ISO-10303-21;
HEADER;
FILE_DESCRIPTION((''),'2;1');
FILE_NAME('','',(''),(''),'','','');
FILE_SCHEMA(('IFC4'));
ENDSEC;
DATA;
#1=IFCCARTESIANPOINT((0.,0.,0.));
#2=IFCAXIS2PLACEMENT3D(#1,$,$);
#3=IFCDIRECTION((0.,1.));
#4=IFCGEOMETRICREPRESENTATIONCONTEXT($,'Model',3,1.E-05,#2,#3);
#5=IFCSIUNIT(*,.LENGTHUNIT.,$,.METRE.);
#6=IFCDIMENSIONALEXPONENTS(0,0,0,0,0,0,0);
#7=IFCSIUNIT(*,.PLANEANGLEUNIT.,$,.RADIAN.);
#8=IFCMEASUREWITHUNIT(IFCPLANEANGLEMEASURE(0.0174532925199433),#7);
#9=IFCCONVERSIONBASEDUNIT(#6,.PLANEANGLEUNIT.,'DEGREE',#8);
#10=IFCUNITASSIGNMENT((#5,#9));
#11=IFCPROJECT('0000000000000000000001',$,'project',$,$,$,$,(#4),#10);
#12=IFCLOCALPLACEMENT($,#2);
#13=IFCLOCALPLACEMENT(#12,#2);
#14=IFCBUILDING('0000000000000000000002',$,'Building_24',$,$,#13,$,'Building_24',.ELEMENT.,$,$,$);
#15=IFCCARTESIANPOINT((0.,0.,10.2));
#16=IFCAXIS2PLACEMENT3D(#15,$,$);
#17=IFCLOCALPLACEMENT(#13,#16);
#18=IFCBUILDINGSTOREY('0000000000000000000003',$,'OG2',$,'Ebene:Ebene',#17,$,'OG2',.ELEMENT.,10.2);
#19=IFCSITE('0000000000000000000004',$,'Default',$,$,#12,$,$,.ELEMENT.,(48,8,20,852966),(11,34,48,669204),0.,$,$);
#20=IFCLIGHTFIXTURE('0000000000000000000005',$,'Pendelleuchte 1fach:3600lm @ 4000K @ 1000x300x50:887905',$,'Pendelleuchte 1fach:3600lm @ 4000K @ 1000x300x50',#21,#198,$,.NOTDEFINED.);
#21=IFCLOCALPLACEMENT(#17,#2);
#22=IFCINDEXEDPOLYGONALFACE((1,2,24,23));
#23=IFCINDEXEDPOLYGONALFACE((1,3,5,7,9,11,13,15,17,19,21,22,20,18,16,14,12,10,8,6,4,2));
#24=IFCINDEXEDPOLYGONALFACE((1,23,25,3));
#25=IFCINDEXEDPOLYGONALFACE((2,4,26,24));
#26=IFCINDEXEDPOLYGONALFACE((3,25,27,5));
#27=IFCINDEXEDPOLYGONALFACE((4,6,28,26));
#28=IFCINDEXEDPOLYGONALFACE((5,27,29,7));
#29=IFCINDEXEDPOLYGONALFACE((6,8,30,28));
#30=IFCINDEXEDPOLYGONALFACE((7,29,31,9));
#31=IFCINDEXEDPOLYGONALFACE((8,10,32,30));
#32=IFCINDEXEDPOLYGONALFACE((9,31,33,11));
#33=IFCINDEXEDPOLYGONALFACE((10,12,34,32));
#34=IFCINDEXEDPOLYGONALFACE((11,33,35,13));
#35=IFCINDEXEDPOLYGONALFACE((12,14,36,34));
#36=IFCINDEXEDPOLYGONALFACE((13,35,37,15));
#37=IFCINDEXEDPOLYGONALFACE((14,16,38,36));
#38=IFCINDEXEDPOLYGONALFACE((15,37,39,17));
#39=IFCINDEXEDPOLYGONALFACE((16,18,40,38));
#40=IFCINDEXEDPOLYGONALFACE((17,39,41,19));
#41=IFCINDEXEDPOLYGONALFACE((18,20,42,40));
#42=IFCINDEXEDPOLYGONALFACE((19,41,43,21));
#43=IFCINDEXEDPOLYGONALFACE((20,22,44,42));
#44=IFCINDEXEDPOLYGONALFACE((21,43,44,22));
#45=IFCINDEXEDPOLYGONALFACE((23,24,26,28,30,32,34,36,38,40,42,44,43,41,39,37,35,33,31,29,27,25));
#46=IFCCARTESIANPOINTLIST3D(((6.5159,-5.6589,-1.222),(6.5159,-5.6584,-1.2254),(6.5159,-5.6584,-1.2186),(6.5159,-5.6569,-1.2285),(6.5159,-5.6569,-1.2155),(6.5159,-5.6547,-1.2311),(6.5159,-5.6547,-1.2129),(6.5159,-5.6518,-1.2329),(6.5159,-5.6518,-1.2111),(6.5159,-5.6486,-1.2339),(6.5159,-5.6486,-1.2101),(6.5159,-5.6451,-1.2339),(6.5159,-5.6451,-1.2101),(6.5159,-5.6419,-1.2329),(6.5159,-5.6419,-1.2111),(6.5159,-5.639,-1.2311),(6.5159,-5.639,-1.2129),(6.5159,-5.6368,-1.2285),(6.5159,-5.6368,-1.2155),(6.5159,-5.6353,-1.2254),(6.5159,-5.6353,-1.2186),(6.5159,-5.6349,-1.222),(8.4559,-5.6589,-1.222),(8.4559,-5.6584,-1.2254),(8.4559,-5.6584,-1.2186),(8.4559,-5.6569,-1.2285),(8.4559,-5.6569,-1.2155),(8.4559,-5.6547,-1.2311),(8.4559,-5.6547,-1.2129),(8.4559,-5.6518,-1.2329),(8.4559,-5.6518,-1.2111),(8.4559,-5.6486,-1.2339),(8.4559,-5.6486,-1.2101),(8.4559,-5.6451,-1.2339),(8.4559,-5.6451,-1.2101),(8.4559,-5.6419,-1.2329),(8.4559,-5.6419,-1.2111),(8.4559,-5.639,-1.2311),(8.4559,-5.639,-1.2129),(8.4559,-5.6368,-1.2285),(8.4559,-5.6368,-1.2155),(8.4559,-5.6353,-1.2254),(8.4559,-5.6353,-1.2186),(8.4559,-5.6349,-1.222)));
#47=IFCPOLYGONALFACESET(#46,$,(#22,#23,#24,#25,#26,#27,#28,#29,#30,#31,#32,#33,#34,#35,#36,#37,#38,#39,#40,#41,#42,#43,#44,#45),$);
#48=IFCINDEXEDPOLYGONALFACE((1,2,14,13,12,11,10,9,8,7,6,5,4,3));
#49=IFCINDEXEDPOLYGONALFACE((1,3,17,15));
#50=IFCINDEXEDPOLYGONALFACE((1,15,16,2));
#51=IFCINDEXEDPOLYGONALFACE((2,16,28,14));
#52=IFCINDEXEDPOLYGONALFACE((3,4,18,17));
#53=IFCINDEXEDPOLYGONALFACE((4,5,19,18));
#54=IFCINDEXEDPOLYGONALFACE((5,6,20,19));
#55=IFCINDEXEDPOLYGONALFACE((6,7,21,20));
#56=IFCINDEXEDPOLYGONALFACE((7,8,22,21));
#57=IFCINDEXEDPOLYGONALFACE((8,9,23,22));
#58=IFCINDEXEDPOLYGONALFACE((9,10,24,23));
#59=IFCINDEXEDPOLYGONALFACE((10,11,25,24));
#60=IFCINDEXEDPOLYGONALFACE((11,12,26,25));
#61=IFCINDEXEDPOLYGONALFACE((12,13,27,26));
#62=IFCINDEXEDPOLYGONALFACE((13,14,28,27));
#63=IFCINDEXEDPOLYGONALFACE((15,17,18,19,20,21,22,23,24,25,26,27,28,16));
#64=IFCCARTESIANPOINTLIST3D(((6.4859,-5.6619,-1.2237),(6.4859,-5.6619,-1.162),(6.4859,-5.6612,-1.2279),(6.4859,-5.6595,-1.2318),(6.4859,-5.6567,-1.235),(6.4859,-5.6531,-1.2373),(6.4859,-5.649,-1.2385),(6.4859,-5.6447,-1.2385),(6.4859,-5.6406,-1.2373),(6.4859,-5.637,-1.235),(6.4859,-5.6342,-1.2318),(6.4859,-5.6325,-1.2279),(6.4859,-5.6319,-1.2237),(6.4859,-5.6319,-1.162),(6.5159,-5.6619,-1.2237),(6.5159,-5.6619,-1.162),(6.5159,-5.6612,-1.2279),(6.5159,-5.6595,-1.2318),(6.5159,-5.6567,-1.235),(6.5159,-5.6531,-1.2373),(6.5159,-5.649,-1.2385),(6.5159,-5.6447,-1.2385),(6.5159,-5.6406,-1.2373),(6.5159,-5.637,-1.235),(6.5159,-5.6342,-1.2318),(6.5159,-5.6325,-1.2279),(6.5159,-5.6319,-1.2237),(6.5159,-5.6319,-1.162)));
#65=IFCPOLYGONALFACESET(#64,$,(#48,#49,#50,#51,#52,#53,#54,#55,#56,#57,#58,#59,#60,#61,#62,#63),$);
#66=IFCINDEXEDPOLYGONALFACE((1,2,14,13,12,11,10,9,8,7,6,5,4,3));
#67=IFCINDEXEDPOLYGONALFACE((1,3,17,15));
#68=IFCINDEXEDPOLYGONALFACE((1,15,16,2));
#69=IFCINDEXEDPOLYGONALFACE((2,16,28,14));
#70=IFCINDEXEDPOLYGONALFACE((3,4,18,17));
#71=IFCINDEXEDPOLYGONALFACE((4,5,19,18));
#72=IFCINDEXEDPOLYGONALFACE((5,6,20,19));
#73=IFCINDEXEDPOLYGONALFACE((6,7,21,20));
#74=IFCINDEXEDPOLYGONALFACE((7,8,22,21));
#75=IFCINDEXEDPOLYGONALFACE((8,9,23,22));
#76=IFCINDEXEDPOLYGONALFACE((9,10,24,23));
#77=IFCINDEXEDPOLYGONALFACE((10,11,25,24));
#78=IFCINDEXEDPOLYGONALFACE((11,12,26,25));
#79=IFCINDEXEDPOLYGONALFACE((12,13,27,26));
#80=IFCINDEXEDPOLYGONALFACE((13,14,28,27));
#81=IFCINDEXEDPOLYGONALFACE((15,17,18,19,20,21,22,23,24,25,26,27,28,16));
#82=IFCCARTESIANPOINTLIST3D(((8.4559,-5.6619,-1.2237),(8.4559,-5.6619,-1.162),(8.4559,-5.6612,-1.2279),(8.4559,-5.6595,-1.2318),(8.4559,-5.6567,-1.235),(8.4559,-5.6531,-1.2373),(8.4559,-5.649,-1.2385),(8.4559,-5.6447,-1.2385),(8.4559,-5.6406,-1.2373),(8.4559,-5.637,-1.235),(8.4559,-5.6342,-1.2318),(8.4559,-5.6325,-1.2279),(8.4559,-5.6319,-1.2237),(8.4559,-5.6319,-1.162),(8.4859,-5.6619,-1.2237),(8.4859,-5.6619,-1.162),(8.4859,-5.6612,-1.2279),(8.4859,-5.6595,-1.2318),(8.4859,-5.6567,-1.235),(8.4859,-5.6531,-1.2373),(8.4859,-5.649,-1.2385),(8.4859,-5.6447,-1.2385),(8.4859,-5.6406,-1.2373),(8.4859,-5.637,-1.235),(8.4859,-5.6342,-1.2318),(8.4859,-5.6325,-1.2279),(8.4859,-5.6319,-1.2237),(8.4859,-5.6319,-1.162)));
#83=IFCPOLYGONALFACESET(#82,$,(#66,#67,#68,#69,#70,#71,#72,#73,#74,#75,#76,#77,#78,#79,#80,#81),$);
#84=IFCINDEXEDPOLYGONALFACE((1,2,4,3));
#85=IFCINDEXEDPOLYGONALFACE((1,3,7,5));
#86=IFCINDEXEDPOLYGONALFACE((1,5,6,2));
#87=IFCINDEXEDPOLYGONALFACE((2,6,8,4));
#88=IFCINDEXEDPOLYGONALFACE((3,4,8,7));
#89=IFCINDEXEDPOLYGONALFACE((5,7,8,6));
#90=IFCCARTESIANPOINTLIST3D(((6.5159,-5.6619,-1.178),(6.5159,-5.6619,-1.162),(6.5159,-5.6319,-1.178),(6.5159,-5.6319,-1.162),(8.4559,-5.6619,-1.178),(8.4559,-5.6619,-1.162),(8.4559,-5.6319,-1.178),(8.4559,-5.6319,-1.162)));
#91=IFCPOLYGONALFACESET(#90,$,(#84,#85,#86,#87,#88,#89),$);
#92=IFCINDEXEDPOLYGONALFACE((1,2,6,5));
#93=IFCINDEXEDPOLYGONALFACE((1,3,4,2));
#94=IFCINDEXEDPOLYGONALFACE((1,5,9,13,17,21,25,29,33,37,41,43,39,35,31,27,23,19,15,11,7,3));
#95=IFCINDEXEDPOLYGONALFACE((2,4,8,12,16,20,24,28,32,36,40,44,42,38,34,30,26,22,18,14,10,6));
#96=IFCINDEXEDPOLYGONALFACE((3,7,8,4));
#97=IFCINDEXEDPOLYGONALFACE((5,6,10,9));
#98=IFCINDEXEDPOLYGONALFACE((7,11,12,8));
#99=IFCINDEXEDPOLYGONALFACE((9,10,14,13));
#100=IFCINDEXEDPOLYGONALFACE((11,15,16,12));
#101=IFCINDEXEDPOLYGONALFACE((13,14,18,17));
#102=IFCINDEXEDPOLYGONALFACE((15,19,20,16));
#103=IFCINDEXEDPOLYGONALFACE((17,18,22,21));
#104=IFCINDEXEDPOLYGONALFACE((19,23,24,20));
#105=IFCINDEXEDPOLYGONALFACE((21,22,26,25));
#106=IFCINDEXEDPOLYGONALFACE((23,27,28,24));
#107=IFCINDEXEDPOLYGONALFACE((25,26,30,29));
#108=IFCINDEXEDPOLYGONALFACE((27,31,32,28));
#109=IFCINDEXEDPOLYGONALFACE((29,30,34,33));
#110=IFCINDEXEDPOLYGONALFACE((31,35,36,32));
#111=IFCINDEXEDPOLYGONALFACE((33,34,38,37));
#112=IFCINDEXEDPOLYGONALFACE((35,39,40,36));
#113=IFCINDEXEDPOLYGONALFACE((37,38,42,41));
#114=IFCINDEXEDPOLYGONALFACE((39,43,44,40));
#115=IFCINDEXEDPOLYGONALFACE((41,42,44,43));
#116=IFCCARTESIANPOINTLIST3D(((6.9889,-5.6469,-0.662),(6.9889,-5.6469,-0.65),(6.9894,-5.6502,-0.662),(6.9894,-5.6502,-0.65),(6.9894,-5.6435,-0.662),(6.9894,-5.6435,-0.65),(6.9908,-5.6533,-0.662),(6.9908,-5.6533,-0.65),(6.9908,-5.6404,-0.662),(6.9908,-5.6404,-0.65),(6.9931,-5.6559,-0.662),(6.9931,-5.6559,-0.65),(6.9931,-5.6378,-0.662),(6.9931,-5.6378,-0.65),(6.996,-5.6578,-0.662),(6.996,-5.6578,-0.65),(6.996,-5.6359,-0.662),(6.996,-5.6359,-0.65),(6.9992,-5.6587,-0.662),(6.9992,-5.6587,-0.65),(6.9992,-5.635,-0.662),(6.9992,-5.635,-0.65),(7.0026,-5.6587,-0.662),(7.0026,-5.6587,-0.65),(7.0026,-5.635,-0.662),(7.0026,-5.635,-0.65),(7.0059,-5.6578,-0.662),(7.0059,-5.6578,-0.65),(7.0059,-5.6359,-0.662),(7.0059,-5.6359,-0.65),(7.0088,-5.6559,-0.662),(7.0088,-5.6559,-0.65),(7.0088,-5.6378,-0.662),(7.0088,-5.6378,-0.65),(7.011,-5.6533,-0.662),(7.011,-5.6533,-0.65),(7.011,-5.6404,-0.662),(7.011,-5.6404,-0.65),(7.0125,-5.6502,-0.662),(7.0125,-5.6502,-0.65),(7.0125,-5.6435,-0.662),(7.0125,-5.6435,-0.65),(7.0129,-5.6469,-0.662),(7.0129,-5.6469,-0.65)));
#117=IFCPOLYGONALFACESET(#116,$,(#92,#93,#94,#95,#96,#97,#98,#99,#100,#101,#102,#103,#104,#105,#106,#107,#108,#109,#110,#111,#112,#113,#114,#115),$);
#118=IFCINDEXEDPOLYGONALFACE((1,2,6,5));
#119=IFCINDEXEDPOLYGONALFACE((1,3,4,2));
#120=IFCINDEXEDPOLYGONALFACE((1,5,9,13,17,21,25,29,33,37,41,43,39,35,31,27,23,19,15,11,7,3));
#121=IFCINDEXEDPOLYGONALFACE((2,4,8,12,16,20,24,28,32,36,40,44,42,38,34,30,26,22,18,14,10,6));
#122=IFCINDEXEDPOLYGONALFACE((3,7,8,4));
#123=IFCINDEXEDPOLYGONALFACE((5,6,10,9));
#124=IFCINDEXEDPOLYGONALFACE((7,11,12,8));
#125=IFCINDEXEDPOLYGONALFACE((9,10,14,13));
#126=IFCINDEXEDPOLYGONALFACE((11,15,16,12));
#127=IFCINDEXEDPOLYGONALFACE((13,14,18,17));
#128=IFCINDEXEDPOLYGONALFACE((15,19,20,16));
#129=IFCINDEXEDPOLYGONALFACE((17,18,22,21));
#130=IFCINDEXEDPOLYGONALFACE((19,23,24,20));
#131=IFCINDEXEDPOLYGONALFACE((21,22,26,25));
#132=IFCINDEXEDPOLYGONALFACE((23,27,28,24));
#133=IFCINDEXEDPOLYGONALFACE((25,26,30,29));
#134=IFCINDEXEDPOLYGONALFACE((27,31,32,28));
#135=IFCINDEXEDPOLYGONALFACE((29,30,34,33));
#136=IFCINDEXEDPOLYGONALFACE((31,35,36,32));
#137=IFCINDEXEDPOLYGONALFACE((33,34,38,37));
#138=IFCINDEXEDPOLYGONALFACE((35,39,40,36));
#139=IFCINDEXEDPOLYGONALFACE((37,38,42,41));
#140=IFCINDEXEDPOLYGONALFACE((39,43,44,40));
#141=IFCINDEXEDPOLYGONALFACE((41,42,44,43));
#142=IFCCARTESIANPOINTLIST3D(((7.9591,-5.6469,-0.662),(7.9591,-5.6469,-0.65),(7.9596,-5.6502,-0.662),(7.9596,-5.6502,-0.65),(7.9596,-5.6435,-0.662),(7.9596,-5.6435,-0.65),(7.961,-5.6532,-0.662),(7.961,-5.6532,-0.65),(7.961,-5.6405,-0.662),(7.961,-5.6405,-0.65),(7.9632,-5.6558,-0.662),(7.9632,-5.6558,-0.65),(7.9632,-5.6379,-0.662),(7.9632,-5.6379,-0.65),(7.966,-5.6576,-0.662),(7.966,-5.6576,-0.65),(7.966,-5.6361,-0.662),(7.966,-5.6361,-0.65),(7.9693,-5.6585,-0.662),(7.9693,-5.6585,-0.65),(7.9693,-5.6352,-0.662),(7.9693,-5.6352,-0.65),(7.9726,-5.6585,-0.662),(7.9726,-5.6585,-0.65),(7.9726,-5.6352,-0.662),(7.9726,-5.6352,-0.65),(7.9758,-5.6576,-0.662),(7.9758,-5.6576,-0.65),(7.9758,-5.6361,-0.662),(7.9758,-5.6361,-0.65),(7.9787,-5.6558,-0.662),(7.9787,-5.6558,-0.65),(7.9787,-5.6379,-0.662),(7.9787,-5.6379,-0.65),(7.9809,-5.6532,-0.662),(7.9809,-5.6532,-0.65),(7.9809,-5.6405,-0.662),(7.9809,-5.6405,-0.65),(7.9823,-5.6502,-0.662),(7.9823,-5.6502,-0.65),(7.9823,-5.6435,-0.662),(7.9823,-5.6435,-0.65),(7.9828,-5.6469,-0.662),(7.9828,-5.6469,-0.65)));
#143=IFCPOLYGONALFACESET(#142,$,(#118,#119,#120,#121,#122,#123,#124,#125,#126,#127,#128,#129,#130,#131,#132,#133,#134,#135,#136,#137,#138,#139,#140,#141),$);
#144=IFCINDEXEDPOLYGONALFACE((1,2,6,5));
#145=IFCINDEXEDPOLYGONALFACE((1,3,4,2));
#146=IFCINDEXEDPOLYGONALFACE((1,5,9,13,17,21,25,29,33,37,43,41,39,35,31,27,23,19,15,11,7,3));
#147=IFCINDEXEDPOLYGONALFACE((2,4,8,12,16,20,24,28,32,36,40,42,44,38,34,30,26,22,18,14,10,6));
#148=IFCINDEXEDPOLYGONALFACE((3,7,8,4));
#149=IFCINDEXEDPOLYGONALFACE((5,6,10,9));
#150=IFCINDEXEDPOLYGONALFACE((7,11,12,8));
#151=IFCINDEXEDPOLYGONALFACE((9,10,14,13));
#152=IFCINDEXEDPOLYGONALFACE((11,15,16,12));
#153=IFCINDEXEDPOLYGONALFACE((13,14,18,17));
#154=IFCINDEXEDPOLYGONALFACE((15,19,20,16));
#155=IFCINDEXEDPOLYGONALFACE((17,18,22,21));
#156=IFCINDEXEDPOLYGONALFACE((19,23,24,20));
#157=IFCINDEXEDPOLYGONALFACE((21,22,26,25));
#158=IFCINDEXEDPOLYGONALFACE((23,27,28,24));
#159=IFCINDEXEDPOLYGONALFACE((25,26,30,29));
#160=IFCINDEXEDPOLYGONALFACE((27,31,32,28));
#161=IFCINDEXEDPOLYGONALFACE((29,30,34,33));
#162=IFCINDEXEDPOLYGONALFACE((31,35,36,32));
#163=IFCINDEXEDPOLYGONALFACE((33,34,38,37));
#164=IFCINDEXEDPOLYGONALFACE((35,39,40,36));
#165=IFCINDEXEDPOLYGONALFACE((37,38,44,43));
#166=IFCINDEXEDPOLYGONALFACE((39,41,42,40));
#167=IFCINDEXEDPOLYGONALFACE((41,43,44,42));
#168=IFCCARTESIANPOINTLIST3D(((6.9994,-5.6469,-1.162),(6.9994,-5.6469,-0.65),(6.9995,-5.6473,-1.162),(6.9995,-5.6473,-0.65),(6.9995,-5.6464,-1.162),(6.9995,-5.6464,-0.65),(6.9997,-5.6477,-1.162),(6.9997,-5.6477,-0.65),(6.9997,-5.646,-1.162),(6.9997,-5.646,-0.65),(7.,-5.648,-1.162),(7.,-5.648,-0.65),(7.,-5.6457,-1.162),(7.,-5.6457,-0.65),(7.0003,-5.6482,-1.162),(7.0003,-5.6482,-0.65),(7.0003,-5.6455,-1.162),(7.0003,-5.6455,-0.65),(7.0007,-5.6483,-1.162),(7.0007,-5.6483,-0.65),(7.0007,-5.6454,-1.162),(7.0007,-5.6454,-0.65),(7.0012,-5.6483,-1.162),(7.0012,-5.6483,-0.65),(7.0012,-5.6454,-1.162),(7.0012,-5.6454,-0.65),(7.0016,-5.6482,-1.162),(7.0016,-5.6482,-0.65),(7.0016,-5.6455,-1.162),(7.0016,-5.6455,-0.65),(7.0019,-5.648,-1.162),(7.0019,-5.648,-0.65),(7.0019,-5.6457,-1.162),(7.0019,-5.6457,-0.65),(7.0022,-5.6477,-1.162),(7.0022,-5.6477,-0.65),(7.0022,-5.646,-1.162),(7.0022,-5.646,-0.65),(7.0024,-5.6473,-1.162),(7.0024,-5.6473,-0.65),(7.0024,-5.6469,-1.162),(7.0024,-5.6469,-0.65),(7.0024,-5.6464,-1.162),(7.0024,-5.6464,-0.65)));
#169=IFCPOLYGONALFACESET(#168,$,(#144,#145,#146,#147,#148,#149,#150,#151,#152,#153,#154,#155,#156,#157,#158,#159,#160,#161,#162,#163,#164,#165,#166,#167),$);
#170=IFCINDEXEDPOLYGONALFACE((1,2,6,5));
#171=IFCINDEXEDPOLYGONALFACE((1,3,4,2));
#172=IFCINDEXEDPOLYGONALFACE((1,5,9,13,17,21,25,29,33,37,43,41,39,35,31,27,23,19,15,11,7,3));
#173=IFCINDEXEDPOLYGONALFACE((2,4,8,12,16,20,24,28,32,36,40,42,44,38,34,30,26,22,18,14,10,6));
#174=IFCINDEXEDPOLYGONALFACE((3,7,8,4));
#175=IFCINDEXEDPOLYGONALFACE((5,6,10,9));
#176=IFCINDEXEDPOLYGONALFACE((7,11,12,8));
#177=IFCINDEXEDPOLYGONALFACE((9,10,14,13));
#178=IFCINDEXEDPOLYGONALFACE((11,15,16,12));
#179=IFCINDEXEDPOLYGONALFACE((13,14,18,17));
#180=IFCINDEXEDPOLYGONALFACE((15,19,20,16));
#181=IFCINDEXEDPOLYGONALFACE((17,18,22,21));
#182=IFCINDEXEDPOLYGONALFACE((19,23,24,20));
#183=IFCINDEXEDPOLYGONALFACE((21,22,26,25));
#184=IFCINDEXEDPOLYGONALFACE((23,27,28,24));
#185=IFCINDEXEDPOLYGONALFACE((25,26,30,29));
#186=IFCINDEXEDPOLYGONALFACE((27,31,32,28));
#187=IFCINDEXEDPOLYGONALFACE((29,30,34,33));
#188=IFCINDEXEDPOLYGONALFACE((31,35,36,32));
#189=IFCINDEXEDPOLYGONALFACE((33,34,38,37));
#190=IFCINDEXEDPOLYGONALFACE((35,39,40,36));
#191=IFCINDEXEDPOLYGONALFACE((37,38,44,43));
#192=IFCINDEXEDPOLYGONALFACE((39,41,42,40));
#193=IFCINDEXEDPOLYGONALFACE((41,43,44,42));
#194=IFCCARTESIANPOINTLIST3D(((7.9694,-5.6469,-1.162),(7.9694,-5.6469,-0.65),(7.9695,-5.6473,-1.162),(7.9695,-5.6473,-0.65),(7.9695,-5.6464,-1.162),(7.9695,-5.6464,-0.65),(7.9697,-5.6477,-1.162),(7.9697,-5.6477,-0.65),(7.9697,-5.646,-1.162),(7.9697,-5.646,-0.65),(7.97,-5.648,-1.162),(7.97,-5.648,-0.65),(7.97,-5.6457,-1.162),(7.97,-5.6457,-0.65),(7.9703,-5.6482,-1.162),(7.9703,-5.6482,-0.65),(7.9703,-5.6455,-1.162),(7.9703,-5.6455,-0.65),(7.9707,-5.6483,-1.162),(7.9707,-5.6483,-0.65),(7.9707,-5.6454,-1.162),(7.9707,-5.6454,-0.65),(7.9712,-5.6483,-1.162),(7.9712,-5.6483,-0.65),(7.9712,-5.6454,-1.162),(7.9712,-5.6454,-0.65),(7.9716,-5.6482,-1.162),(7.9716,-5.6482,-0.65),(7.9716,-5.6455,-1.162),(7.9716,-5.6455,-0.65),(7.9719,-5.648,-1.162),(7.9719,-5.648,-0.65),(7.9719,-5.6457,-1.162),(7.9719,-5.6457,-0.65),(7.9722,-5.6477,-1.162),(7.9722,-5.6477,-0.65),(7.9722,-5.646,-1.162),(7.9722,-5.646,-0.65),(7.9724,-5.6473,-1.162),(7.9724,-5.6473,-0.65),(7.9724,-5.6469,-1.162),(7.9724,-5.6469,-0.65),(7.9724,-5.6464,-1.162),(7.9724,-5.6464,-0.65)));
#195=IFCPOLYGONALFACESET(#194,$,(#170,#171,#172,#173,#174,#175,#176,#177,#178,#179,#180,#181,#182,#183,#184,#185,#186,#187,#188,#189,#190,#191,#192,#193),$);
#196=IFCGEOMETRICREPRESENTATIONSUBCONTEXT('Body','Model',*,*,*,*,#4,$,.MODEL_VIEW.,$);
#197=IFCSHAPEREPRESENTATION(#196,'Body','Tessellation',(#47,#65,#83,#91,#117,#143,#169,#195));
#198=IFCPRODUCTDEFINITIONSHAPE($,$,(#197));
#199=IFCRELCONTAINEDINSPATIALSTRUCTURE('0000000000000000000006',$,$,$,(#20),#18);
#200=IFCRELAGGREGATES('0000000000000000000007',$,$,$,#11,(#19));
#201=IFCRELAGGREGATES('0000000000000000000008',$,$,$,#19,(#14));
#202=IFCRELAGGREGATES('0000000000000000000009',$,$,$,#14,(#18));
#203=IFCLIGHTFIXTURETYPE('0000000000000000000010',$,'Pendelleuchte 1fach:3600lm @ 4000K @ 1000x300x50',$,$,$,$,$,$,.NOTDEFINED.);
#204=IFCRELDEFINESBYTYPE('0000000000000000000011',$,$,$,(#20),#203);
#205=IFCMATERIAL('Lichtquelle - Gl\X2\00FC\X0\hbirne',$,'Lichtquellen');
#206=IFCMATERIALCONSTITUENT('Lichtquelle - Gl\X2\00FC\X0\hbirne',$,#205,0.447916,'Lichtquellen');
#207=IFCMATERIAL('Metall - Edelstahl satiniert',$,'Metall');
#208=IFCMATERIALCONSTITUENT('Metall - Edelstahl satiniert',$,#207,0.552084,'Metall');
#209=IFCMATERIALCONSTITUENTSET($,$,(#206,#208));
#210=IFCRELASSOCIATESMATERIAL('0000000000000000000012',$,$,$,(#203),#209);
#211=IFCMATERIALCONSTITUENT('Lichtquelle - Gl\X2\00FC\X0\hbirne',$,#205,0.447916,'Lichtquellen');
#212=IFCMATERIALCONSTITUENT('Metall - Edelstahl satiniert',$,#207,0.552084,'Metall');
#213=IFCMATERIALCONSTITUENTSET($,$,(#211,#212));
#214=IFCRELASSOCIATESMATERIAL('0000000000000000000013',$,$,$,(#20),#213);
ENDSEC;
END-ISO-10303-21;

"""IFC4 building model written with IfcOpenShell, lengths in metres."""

from ifc_helpers import new_model, entity, si_unit, converted_unit, direction, frame, origin, place, context, subcontext, project, spatial, line, arc, indexed_curve, outline, extrude, source, transform, mapped, material, constituent, constituent_set, type_object, type_shapes, element, save


model = new_model("IFC4")

# Units and contexts
model_context = context("Model", 3, precision=1e-05, world=origin(), true_north=direction((0.0, 1.0)))
body_context = subcontext(model_context, "Body", "Model", "MODEL_VIEW")
ifc_project = project(units=[si_unit("LENGTHUNIT", "METRE"), converted_unit("PLANEANGLEUNIT", "DEGREE", entity("IfcPlaneAngleMeasure", 0.0174532925199433), si_unit("PLANEANGLEUNIT", "RADIAN"), dimensions=[0, 0, 0, 0, 0, 0, 0])], contexts=[model_context])

# Site, building, storey
site_placement = place(None, origin())
site = spatial("IfcSite", under=ifc_project, at=site_placement, Name="Default", CompositionType="ELEMENT", RefLatitude=(48, 8, 20, 852966), RefLongitude=(11, 34, 48, 669204), RefElevation=0.0)
building_placement = place(site_placement, origin())
building = spatial("IfcBuilding", under=site, at=building_placement, Name="Building_24", LongName="Building_24", CompositionType="ELEMENT")
storey_placement = place(building_placement, frame((0.0, 0.0, 10.2)))
storey = spatial("IfcBuildingStorey", under=building, at=storey_placement, Name="OG2", ObjectType="Ebene:Ebene", LongName="OG2", CompositionType="ELEMENT", Elevation=10.2)

# Light fixture
ifc_material_1 = material(Name="Lichtquelle - Glühbirne", Category="Lichtquellen")
ifc_material_2 = material(Name="Metall - Edelstahl satiniert", Category="Metall")
ifc_constituent_1 = constituent(ifc_material_1, Name="Lichtquelle - Glühbirne", Category="Lichtquellen", fraction=0.447916)
ifc_constituent_2 = constituent(ifc_material_2, Name="Metall - Edelstahl satiniert", Category="Metall", fraction=0.552084)
ifc_constituent_set_1 = constituent_set(constituents=[ifc_constituent_1, ifc_constituent_2])
light_fixture_type_1 = type_object("IfcLightFixtureType", Name="Pendelleuchte 1fach:3600lm @ 4000K @ 1000x300x50", PredefinedType="NOTDEFINED", material=ifc_constituent_set_1)
shared_shape_1 = source(origin(), body_context, "Body", "SweptSolid", [
    extrude(outline(indexed_curve([(-0.012, 0.0), (0.0, -0.012), (0.012, 0.0), (0.0, 0.012)], segments=[arc(1, 2, 3), arc(3, 4, 1)], self_intersect=False)), frame((-0.97, 0.0, -0.572), z_axis=(1.0, 0.0, 0.0), x_axis=(0.0, -1.0, 0.0)), (0.0, 0.0, 1.0), 1.94),
    extrude(outline(indexed_curve([(0.015, 0.0308), (0.0, 0.0458), (-0.015, 0.0308), (-0.015, -0.0308), (0.015, -0.0308)], segments=[arc(1, 2, 3), line(3, 4, 5, 1)], self_intersect=False)), frame((0.97, 0.0, -0.5428), z_axis=(1.0, 0.0, 0.0), x_axis=(0.0, -1.0, 0.0)), (0.0, 0.0, 1.0), 0.03),
    extrude(outline(indexed_curve([(0.015, 0.0308), (0.0, 0.0458), (-0.015, 0.0308), (-0.015, -0.0308), (0.015, -0.0308)], segments=[arc(1, 2, 3), line(3, 4, 5, 1)], self_intersect=False)), frame((-1.0, 0.0, -0.5428), z_axis=(1.0, 0.0, 0.0), x_axis=(0.0, -1.0, 0.0)), (0.0, 0.0, 1.0), 0.03),
    extrude(outline(indexed_curve([(-0.015, -0.97), (0.015, -0.97), (0.015, 0.97), (-0.015, 0.97), (-0.015, -0.97)], self_intersect=False)), frame((0.0, 0.0, -0.528), z_axis=(0.0, 0.0, 1.0), x_axis=(0.0, 1.0, 0.0)), (0.0, 0.0, 1.0), 0.016),
    extrude(outline(indexed_curve([(-0.012, 0.0), (0.0, -0.012), (0.012, 0.0), (0.0, 0.012)], segments=[arc(1, 2, 3), arc(3, 4, 1)], self_intersect=False)), frame((0.485, 0.0, -0.012)), (0.0, 0.0, 1.0), 0.012),
    extrude(outline(indexed_curve([(-0.0118, 0.0), (0.0, -0.0118), (0.0118, 0.0), (0.0, 0.0118)], segments=[arc(1, 2, 3), arc(3, 4, 1)], self_intersect=False)), frame((-0.485, 0.0, -0.012)), (0.0, 0.0, 1.0), 0.012),
    extrude(outline(indexed_curve([(-0.0015, 0.0), (0.0, -0.0015), (0.0015, 0.0), (0.0, 0.0015)], segments=[arc(1, 2, 3), arc(3, 4, 1)], self_intersect=False)), frame((0.485, 0.0, -0.512)), (0.0, 0.0, 1.0), 0.512),
    extrude(outline(indexed_curve([(-0.0015, 0.0), (0.0, -0.0015), (0.0015, 0.0), (0.0, 0.0015)], segments=[arc(1, 2, 3), arc(3, 4, 1)], self_intersect=False)), frame((-0.485, 0.0, -0.512)), (0.0, 0.0, 1.0), 0.512),
])
type_shapes(light_fixture_type_1, [shared_shape_1])
ifc_constituent_3 = constituent(ifc_material_1, Name="Lichtquelle - Glühbirne", Category="Lichtquellen", fraction=0.447916)
ifc_constituent_4 = constituent(ifc_material_2, Name="Metall - Edelstahl satiniert", Category="Metall", fraction=0.552084)
ifc_constituent_set_2 = constituent_set(constituents=[ifc_constituent_3, ifc_constituent_4])
light_fixture_1_placement = place(storey_placement, frame((7.4859, -5.6469, -0.65), z_axis=(0.0, 0.0, 1.0), x_axis=(-1.0, 0.0, 0.0)))
element("IfcLightFixture", 1, at=light_fixture_1_placement, inside=storey, type_object=light_fixture_type_1, material=ifc_constituent_set_2, Name="Pendelleuchte 1fach:3600lm @ 4000K @ 1000x300x50:887905", ObjectType="Pendelleuchte 1fach:3600lm @ 4000K @ 1000x300x50", PredefinedType="NOTDEFINED", context=body_context, shape_type="MappedRepresentation", body=[
    mapped(shared_shape_1, transform((0.0, 0.0, 0.0), scale=1.0)),
])

save(model, "model.ifc")
